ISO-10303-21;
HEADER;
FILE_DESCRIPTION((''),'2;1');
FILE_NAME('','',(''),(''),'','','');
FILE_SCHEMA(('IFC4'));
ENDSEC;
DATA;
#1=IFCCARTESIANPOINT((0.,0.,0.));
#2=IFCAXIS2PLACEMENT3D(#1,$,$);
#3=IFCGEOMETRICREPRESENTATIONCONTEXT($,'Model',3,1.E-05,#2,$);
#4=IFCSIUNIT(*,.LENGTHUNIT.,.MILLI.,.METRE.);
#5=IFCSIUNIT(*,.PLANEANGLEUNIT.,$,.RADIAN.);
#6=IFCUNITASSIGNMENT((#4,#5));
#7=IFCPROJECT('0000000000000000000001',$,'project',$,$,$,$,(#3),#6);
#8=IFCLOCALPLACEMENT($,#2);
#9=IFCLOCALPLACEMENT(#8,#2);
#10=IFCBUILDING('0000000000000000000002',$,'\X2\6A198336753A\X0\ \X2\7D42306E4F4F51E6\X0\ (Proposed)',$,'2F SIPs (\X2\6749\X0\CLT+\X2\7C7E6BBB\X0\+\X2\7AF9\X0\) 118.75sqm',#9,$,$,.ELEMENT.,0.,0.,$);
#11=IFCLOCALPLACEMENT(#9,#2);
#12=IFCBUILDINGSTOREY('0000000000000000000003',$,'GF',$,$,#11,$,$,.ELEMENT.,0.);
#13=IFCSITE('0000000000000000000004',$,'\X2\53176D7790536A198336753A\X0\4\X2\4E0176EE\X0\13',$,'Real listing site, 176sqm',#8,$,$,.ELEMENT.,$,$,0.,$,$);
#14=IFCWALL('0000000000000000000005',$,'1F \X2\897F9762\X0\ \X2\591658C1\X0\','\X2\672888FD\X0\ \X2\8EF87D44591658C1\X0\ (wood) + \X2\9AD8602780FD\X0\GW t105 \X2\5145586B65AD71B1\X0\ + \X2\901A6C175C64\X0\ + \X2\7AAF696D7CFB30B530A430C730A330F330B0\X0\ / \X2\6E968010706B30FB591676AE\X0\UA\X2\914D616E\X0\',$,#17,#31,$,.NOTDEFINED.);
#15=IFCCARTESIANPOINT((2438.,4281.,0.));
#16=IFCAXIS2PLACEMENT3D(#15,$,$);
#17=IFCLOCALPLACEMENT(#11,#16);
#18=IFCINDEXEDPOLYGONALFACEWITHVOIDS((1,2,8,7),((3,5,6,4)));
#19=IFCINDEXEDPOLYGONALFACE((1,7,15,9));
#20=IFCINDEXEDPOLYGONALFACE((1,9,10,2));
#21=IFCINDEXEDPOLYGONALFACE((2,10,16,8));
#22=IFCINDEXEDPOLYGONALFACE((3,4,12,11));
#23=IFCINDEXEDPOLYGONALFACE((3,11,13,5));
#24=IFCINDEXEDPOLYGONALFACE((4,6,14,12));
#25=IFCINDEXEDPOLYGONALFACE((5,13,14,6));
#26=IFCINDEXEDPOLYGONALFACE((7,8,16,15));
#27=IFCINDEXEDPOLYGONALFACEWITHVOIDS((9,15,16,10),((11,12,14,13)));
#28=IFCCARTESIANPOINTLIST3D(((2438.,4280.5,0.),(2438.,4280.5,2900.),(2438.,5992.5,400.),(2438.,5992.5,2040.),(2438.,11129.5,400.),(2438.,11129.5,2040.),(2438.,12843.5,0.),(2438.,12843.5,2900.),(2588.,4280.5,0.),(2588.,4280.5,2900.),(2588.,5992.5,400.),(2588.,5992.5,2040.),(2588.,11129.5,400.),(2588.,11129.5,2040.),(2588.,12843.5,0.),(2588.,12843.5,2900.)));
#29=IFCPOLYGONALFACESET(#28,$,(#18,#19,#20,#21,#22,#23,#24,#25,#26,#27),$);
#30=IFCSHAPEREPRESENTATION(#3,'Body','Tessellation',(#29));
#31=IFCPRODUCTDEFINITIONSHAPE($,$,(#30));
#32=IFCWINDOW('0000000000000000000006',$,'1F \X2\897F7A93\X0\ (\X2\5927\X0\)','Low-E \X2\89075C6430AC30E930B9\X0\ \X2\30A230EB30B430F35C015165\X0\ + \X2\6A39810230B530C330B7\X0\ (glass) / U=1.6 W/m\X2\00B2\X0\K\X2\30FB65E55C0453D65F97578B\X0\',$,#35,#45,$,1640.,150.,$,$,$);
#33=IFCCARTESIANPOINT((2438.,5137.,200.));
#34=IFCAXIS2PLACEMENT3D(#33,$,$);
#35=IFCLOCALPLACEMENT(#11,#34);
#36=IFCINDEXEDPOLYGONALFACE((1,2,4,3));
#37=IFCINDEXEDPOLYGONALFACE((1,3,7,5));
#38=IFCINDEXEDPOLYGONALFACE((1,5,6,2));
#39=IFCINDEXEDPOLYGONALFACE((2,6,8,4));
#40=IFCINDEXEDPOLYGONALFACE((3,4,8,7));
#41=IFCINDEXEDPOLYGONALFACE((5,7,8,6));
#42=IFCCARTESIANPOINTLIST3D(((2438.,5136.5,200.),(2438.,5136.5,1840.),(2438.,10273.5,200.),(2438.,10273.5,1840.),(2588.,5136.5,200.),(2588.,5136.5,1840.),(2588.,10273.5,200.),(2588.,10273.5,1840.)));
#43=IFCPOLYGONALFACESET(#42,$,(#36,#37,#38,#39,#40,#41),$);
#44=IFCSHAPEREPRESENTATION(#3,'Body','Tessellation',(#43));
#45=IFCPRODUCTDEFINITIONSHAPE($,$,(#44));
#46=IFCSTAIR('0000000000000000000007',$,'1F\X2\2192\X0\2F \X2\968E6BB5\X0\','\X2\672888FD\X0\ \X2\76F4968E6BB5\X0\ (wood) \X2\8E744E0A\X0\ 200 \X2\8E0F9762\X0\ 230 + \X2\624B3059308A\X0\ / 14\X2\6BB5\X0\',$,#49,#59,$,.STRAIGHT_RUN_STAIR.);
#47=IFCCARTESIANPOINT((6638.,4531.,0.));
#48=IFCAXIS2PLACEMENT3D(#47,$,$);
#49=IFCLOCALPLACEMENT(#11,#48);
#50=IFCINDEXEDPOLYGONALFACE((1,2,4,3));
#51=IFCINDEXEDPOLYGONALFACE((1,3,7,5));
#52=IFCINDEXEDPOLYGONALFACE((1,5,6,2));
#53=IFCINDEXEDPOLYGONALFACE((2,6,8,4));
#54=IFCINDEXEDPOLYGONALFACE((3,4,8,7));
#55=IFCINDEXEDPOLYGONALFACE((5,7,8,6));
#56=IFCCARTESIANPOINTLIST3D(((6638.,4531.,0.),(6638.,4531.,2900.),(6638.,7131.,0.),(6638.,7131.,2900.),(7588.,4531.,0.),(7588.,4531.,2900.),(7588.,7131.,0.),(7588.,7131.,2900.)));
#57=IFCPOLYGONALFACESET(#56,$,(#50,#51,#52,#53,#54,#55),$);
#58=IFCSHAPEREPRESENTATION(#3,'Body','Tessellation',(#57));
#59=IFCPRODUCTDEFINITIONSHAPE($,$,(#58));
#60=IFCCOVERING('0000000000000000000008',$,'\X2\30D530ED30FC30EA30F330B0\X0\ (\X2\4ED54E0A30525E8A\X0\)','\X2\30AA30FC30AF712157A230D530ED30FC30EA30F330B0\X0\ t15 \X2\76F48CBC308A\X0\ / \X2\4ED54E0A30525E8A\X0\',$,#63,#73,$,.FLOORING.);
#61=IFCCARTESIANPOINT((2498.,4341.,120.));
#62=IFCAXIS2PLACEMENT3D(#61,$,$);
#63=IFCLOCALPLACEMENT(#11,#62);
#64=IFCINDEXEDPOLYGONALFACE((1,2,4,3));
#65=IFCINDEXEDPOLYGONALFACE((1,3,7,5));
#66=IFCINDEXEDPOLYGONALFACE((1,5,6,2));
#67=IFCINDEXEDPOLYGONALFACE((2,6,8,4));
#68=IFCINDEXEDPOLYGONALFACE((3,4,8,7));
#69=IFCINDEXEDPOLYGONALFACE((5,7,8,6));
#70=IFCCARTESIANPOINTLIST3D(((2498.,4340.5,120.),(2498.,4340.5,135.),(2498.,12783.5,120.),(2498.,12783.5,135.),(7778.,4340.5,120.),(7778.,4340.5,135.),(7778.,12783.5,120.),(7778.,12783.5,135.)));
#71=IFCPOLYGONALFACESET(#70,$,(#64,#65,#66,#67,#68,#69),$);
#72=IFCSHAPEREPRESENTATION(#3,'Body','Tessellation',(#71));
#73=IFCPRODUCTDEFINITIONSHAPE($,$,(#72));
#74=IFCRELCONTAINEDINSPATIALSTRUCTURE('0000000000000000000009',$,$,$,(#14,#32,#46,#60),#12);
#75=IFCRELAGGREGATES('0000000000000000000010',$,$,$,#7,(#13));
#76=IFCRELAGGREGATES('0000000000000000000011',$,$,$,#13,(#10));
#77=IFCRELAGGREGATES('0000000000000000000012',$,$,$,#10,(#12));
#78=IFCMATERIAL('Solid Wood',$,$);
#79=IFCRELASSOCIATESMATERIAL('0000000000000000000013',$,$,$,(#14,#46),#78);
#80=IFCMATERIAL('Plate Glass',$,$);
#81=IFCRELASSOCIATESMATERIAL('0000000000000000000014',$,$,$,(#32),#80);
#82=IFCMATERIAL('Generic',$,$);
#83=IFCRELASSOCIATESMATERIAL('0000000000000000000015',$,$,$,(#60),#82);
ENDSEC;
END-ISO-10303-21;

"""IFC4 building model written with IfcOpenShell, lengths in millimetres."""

from ifc_helpers import new_model, si_unit, frame, frame_2d, origin, place, context, project, spatial, rectangle, extrude, material, element, fill, save


model = new_model("IFC4")

# Units and contexts
model_context = context("Model", 3, precision=1e-05, world=origin())
ifc_project = project(units=[si_unit("LENGTHUNIT", "METRE", prefix="MILLI"), si_unit("PLANEANGLEUNIT", "RADIAN")], contexts=[model_context])

# Site, building, storey
site_placement = place(None, origin())
site = spatial("IfcSite", under=ifc_project, at=site_placement, Name="北海道標茶町4丁目13", ObjectType="Real listing site, 176sqm", CompositionType="ELEMENT", RefElevation=0.0)
building_placement = place(site_placement, origin())
building = spatial("IfcBuilding", under=site, at=building_placement, Name="標茶町 終の住処 (Proposed)", ObjectType="2F SIPs (杉CLT+籾殻+竹) 118.75sqm", CompositionType="ELEMENT", ElevationOfRefHeight=0.0, ElevationOfTerrain=0.0)
storey_placement = place(building_placement, origin())
storey = spatial("IfcBuildingStorey", under=building, at=storey_placement, Name="GF", CompositionType="ELEMENT", Elevation=0.0)

# Shared definitions
ifc_material_1 = material(Name="Solid Wood")
ifc_material_2 = material(Name="Generic")

# Shared definitions
ifc_material_3 = material(Name="Plate Glass")

# Wall, opening, window
wall_1_placement = place(storey_placement, frame((2438.0, 4281.0, 0.0)))
wall_1 = element("IfcWall", 1, at=wall_1_placement, inside=storey, material=ifc_material_1, Name="1F 西面 外壁", Description="木製 軸組外壁 (wood) + 高性能GW t105 充填断熱 + 通気層 + 窯業系サイディング / 準耐火・外皮UA配慮", PredefinedType="NOTDEFINED", context=model_context, shape_type="SweptSolid", body=[
    extrude(rectangle(XDim=150.0, YDim=8563.0, at=frame_2d((75.0, 4281.0))), frame((2438.0, 4281.0, 0.0)), (0.0, 0.0, 1.0), 2900.0),
])
opening_1_placement = place(storey_placement, frame((2438.0, 5137.0, 200.0)))
opening_1 = element("IfcOpeningElement", 2, at=opening_1_placement, cuts=wall_1, PredefinedType="NOTDEFINED", context=model_context, shape_type="SweptSolid", body=[
    extrude(rectangle(XDim=150.0, YDim=5137.0, at=frame_2d((75.0, 2568.0))), frame((2438.0, 5137.0, 200.0)), (0.0, 0.0, 1.0), 1640.0),
])
window_1_placement = place(storey_placement, frame((2438.0, 5137.0, 200.0)))
window_1 = element("IfcWindow", 3, at=window_1_placement, inside=storey, material=ifc_material_3, Name="1F 西窓 (大)", Description="Low-E 複層ガラス アルゴン封入 + 樹脂サッシ (glass) / U=1.6 W/m²K・日射取得型", OverallHeight=1640.0, OverallWidth=150.0, context=model_context, shape_type="SweptSolid", body=[
    extrude(rectangle(XDim=150.0, YDim=5137.0, at=frame_2d((75.0, 2568.0))), frame((2438.0, 5137.0, 200.0)), (0.0, 0.0, 1.0), 1640.0),
])
fill(opening_1, window_1)

# Stair
stair_placement = place(storey_placement, frame((6638.0, 4531.0, 0.0)))
element("IfcStair", 4, at=stair_placement, inside=storey, material=ifc_material_1, Name="1F→2F 階段", Description="木製 直階段 (wood) 蹴上 200 踏面 230 + 手すり / 14段", PredefinedType="STRAIGHT_RUN_STAIR", context=model_context, shape_type="SweptSolid", body=[
    extrude(rectangle(XDim=950.0, YDim=2600.0, at=frame_2d((475.0, 1300.0))), frame((6638.0, 4531.0, 0.0)), (0.0, 0.0, 1.0), 2900.0),
])

# Covering
covering_placement = place(storey_placement, frame((2498.0, 4341.0, 120.0)))
element("IfcCovering", 5, at=covering_placement, inside=storey, material=ifc_material_2, Name="フローリング (仕上げ床)", Description="オーク無垢フローリング t15 直貼り / 仕上げ床", PredefinedType="FLOORING", context=model_context, shape_type="SweptSolid", body=[
    extrude(rectangle(XDim=5280.0, YDim=8443.0, at=frame_2d((2640.0, 4221.0))), frame((2498.0, 4341.0, 120.0)), (0.0, 0.0, 1.0), 15.0),
])

save(model, "model.ifc")
